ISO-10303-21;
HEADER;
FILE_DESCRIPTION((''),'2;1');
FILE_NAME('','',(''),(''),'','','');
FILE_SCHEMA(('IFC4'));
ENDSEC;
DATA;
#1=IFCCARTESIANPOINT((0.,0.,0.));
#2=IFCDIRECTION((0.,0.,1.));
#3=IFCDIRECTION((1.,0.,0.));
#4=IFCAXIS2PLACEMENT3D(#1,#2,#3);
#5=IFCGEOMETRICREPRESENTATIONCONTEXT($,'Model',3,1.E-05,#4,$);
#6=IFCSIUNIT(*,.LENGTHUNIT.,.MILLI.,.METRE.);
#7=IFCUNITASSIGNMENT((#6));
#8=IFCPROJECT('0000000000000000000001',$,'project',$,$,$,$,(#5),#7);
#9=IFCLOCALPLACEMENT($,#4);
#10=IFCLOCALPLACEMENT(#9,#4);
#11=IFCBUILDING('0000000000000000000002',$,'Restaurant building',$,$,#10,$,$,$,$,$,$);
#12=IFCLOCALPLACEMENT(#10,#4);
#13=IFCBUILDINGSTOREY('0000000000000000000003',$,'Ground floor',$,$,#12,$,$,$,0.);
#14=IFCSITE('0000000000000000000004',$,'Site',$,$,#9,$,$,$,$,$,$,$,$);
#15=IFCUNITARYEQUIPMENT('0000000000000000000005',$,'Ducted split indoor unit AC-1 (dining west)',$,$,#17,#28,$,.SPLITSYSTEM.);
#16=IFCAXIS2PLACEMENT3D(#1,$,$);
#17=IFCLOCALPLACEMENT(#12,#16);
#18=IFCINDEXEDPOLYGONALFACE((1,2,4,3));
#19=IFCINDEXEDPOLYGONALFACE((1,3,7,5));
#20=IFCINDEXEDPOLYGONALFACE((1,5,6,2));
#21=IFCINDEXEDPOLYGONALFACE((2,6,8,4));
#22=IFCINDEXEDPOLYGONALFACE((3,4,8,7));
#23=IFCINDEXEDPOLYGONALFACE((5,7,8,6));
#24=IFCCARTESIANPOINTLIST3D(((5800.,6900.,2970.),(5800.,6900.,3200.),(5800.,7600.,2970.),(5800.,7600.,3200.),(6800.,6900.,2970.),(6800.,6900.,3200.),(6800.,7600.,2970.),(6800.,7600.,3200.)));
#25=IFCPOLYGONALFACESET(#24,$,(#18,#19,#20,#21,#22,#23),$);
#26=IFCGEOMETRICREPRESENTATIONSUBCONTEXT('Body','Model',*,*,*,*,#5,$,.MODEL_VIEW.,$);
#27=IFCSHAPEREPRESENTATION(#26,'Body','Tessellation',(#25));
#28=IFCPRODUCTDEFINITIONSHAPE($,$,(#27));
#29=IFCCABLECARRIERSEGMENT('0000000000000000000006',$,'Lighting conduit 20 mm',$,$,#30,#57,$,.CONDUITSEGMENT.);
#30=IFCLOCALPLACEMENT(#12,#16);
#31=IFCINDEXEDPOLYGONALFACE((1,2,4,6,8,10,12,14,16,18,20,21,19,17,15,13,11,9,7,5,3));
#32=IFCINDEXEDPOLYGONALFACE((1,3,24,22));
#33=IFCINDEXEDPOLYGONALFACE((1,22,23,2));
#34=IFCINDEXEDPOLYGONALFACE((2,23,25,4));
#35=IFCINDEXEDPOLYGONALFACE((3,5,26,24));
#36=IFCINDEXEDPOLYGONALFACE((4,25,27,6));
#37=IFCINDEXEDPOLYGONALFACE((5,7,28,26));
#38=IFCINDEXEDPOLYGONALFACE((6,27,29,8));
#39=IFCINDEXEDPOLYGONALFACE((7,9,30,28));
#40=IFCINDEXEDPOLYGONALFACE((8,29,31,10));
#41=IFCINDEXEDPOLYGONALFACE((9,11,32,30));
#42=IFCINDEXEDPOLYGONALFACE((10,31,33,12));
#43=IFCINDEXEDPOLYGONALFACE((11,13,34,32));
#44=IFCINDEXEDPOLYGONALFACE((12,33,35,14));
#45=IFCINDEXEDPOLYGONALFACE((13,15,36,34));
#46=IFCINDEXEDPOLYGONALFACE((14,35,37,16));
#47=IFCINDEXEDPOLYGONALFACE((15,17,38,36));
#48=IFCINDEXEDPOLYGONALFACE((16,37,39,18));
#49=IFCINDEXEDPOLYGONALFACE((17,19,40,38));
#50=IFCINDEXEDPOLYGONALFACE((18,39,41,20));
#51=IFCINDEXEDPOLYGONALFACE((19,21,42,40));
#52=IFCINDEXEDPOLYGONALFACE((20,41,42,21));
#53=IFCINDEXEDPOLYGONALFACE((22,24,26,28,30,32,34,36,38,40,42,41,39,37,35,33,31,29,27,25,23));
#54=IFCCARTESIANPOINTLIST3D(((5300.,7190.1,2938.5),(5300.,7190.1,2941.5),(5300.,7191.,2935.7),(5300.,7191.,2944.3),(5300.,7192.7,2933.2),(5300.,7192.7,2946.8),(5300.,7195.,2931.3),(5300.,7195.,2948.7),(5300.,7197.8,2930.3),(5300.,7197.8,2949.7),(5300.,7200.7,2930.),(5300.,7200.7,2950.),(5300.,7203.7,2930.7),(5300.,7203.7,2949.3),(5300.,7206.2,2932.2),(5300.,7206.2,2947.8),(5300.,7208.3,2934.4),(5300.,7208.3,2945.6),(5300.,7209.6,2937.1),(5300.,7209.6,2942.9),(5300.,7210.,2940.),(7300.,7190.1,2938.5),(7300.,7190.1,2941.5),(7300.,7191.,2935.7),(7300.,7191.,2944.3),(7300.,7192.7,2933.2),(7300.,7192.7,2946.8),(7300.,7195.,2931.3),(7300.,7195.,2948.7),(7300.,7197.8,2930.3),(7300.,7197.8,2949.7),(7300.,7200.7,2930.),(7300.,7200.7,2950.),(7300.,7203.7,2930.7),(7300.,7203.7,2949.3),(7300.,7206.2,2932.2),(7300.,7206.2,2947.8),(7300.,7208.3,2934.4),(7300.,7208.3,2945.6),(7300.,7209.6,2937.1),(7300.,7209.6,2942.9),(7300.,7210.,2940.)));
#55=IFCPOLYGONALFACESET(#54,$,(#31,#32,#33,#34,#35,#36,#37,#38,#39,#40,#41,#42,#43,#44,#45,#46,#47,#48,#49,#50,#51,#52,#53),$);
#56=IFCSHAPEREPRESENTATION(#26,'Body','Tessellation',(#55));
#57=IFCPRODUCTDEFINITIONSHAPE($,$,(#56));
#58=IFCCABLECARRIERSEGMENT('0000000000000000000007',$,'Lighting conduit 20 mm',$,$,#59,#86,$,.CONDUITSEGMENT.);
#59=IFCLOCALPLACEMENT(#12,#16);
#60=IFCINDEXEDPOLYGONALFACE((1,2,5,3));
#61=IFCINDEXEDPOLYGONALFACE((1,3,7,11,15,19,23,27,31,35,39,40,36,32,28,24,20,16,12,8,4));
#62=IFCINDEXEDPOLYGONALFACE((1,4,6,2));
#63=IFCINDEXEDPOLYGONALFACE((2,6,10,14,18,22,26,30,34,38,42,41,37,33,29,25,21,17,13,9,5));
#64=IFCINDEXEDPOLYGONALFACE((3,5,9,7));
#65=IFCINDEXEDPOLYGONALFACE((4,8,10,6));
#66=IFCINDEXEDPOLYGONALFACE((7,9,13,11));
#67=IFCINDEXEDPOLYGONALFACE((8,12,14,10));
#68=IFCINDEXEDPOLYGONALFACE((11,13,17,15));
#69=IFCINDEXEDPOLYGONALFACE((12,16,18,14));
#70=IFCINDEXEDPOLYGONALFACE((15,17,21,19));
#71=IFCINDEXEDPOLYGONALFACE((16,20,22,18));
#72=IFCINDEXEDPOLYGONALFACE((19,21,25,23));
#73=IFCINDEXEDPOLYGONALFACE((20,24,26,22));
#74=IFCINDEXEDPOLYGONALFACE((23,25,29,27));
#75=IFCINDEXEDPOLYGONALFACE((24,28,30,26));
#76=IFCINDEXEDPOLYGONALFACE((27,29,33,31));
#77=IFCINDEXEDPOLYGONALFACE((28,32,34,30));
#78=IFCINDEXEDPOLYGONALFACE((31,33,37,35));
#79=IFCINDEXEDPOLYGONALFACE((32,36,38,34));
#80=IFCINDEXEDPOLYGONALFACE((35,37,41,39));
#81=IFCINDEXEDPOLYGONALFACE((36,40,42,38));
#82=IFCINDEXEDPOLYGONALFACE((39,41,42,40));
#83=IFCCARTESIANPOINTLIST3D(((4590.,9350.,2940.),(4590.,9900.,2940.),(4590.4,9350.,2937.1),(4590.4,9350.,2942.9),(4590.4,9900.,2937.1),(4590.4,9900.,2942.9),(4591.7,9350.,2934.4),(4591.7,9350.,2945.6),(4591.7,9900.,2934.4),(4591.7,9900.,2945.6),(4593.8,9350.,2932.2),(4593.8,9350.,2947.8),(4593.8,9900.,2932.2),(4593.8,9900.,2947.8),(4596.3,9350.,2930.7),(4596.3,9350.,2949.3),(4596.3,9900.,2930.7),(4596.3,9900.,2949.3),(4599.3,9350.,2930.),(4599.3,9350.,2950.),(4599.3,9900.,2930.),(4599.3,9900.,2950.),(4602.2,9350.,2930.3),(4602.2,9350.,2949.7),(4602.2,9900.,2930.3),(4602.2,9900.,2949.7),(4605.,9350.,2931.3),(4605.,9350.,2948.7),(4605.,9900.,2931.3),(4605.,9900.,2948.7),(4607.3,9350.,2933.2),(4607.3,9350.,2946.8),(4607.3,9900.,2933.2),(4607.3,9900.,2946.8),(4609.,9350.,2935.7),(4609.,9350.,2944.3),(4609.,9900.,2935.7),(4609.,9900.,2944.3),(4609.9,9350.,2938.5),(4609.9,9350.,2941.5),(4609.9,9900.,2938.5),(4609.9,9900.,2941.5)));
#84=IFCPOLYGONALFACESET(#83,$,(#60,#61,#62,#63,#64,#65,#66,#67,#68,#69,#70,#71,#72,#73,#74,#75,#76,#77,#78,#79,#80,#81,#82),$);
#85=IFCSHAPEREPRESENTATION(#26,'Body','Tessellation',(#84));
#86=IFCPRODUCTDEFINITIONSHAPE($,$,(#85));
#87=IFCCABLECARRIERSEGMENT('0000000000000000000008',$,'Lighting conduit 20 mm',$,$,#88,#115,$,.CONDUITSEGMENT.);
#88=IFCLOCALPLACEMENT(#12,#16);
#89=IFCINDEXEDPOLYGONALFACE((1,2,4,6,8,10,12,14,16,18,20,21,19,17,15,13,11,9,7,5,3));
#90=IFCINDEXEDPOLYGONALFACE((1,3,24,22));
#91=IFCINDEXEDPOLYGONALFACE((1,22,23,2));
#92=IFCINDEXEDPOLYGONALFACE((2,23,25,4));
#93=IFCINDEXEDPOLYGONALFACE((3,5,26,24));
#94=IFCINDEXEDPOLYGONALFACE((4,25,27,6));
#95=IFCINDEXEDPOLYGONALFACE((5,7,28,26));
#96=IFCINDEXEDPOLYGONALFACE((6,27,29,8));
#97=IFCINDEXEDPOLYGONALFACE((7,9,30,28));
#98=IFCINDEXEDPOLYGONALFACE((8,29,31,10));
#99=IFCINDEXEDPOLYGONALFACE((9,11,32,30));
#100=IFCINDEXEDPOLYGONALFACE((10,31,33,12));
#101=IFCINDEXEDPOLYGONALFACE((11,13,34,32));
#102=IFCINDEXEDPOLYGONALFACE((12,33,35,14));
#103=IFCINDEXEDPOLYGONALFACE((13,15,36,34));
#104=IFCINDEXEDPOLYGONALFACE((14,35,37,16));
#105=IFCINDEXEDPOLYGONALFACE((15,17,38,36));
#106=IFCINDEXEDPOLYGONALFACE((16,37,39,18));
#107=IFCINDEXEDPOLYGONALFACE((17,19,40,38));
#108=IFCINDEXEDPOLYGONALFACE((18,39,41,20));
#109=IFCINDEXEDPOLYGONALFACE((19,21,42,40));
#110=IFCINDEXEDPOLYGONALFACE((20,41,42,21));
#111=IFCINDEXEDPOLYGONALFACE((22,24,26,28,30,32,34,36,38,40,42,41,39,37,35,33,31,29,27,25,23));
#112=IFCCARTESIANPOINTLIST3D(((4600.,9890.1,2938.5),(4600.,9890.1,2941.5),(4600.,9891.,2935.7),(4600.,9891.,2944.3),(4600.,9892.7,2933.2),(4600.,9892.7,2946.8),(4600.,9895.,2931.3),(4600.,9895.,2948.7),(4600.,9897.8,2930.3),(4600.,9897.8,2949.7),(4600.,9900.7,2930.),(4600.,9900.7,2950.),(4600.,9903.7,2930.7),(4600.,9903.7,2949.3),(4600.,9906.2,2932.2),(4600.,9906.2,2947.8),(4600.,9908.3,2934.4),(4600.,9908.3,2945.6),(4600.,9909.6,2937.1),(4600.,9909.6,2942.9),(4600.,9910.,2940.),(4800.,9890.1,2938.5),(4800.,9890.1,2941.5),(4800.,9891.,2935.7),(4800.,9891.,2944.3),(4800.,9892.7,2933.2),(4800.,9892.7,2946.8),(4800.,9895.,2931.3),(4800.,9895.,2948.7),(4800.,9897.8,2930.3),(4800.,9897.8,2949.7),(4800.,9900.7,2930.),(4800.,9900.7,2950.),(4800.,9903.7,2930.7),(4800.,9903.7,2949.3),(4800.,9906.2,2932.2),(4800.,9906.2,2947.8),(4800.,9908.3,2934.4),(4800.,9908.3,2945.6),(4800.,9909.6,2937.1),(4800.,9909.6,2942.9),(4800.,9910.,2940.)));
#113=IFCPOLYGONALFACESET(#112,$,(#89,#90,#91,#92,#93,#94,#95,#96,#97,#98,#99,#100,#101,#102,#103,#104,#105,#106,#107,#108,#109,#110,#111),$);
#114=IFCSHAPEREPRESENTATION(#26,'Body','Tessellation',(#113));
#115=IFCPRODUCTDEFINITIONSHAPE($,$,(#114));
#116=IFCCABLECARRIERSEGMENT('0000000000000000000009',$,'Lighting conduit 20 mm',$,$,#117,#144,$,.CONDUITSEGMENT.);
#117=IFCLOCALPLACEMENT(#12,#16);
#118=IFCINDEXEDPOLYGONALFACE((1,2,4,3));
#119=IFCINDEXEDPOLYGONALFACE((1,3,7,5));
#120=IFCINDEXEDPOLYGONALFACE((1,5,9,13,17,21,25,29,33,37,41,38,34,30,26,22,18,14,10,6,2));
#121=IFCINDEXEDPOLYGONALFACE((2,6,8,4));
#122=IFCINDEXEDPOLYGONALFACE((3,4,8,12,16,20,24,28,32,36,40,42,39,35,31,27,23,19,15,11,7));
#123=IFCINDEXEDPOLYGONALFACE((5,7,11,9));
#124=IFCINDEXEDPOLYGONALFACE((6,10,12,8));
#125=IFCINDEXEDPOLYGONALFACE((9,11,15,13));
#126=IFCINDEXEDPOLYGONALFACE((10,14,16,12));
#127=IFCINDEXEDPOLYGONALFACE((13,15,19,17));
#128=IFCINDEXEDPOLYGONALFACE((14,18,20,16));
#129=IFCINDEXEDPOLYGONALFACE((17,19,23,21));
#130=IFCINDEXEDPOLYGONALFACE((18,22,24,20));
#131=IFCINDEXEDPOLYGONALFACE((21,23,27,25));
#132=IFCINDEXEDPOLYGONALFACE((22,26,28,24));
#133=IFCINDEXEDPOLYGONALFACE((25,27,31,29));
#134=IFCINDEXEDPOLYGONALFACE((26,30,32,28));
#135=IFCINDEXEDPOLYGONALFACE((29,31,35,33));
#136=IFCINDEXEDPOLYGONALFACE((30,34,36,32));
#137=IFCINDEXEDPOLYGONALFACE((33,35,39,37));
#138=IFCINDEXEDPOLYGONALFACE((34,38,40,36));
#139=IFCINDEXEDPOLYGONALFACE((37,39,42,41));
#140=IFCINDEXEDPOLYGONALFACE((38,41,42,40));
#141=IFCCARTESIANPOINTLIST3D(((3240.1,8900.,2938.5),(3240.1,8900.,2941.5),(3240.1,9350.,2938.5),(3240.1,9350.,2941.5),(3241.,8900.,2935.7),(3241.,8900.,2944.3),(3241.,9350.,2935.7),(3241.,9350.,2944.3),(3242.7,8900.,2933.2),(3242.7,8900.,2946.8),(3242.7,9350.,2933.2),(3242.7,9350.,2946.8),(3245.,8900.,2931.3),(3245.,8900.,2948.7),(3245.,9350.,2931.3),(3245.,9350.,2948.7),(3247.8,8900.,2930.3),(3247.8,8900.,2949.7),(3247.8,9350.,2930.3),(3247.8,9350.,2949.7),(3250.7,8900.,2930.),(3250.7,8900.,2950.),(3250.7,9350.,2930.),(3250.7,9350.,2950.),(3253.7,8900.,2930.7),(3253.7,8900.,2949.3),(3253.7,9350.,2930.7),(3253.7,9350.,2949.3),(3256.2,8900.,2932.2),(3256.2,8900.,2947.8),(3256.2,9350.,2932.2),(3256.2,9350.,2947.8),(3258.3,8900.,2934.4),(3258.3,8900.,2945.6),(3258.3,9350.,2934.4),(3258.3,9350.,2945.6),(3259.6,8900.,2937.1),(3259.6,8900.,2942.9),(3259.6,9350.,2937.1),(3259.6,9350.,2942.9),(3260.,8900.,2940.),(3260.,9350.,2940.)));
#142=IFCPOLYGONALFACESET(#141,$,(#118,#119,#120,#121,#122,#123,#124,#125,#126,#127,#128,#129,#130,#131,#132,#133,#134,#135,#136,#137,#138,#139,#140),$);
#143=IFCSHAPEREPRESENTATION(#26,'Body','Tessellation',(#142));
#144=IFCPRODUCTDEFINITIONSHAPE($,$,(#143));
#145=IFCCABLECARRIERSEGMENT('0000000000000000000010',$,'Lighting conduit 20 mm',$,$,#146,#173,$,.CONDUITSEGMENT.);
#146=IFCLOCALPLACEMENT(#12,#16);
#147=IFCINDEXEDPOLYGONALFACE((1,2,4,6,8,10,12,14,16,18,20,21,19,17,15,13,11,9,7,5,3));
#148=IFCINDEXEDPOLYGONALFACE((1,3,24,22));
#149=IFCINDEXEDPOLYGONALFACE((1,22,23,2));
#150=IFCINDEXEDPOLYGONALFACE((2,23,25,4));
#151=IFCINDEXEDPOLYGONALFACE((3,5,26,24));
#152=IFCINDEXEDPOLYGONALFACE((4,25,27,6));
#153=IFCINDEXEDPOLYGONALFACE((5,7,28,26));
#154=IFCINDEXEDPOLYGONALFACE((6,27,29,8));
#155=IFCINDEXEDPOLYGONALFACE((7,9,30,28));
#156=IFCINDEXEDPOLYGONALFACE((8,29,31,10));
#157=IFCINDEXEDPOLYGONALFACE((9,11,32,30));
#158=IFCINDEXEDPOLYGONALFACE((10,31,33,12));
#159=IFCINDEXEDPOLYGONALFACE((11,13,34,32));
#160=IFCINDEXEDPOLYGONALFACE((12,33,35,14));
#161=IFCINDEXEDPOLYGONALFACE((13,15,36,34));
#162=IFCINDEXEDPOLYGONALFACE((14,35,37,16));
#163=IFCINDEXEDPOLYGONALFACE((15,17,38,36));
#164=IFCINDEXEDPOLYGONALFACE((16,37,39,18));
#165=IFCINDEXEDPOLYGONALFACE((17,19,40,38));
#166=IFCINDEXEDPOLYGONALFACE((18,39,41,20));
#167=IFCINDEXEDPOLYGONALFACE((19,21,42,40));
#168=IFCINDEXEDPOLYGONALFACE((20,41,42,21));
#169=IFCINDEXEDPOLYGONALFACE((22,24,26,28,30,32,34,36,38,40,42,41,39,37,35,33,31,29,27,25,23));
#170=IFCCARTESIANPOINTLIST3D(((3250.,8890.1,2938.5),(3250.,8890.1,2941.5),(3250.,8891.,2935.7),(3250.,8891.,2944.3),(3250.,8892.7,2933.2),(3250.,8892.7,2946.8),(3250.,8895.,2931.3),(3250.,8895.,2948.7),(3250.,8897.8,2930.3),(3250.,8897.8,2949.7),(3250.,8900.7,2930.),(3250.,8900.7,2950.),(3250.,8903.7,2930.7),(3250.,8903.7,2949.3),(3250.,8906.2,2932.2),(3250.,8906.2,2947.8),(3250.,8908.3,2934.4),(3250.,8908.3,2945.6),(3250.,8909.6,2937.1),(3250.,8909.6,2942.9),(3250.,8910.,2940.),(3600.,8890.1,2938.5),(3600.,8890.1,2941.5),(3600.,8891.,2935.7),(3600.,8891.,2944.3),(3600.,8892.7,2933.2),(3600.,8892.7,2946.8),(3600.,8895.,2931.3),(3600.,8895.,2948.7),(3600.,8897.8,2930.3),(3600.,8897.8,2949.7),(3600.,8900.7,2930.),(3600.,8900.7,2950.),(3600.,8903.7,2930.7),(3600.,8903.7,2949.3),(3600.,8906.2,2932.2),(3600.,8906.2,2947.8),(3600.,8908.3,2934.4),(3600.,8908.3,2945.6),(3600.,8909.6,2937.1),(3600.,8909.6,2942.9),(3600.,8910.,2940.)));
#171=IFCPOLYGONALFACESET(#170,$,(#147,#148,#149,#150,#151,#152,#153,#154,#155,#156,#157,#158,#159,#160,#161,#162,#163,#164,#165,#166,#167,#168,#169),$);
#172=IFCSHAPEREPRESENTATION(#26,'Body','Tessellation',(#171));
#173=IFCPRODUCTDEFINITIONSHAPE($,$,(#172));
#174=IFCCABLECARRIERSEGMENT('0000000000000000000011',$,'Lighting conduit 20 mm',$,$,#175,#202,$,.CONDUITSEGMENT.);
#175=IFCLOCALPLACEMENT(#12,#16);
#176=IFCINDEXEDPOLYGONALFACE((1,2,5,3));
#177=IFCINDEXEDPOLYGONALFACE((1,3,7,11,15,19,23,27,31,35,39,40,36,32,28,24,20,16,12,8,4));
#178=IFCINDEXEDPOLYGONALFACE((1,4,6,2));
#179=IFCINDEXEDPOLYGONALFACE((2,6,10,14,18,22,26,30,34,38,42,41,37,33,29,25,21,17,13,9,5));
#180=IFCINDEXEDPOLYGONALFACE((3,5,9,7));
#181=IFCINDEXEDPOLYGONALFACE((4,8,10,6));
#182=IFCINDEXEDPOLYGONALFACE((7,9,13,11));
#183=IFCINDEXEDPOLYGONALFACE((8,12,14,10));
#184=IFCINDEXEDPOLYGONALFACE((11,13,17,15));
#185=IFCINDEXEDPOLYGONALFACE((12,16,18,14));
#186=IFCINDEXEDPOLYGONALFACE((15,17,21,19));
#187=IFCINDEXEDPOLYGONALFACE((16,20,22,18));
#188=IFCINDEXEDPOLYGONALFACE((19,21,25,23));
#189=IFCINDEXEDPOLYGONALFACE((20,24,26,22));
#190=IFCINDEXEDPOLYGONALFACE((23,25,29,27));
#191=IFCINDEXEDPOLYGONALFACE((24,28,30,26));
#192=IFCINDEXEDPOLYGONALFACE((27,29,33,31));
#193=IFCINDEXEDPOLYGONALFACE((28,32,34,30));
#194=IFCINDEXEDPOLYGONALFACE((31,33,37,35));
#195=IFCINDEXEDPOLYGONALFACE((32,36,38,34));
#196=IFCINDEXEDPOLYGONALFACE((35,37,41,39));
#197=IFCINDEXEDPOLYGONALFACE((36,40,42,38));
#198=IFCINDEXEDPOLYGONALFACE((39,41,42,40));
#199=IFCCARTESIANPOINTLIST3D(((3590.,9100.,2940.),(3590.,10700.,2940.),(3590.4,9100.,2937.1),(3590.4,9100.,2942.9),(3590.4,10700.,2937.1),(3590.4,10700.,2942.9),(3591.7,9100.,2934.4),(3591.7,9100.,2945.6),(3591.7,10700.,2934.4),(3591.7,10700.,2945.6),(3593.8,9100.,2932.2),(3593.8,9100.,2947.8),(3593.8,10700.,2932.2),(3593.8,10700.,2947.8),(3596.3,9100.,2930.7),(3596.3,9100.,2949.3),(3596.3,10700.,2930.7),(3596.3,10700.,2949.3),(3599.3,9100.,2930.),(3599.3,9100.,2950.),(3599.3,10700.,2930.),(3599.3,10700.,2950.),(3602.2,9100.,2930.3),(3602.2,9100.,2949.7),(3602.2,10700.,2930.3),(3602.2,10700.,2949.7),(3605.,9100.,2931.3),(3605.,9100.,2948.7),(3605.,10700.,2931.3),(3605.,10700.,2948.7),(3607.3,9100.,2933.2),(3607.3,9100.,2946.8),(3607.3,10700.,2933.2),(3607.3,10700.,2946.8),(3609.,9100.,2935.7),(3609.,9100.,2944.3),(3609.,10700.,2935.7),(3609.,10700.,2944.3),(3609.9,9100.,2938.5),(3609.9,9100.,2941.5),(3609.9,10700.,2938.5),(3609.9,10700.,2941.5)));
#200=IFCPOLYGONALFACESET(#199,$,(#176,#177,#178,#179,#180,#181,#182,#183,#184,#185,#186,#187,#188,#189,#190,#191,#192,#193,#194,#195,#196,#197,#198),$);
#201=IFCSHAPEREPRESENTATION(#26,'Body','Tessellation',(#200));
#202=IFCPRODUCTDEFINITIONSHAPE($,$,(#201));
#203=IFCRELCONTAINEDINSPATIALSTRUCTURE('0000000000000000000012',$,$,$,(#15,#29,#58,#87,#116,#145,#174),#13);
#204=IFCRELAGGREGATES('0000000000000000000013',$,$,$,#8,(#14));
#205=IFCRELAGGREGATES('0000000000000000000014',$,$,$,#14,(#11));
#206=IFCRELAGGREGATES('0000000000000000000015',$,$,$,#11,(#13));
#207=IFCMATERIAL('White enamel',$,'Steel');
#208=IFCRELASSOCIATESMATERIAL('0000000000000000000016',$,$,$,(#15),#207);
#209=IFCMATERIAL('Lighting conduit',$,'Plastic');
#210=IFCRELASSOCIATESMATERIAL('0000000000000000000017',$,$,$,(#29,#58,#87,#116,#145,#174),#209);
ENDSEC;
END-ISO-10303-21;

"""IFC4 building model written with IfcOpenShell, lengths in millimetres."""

from ifc_helpers import new_model, si_unit, frame, origin_with_axes, origin_2d, place, context, subcontext, project, spatial, rectangle, circle, extrude, material, element, save


model = new_model("IFC4")

# Units and contexts
model_context = context("Model", 3, precision=1e-05, world=origin_with_axes())
body_context = subcontext(model_context, "Body", "Model", "MODEL_VIEW")
ifc_project = project(units=[si_unit("LENGTHUNIT", "METRE", prefix="MILLI")], contexts=[model_context])

# Site, building, storey
site_placement = place(None, origin_with_axes())
site = spatial("IfcSite", under=ifc_project, at=site_placement, Name="Site")
building_placement = place(site_placement, origin_with_axes())
building = spatial("IfcBuilding", under=site, at=building_placement, Name="Restaurant building")
storey_placement = place(building_placement, origin_with_axes())
storey = spatial("IfcBuildingStorey", under=building, at=storey_placement, Name="Ground floor", Elevation=0.0)

# Shared definitions
ifc_material_1 = material(Name="White enamel", Category="Steel")

# Unitary equipment
unitary_equipment_placement = place(storey_placement, frame((6300.0, 7250.0, 0.0)))
element("IfcUnitaryEquipment", 1, at=unitary_equipment_placement, inside=storey, material=ifc_material_1, Name="Ducted split indoor unit AC-1 (dining west)", PredefinedType="SPLITSYSTEM", context=body_context, shape_type="SweptSolid", body=[
    extrude(rectangle(XDim=1000.0, YDim=700.0, at=origin_2d()), frame((0.0, 0.0, 2970.0)), (0.0, 0.0, 1.0), 230.0),
])

# Cable carrier segments
ifc_material_2 = material(Name="Lighting conduit", Category="Plastic")
cable_carrier_segment_1_placement = place(storey_placement, frame((5300.0, 7200.0, 2940.0)))
element("IfcCableCarrierSegment", 2, at=cable_carrier_segment_1_placement, inside=storey, material=ifc_material_2, Name="Lighting conduit 20 mm", PredefinedType="CONDUITSEGMENT", context=body_context, shape_type="SweptSolid", body=[
    extrude(circle(Radius=10.0, at=origin_2d()), frame((0.0, 0.0, 0.0), z_axis=(1.0, 0.0, 0.0), x_axis=(0.0, 1.0, 0.0)), (0.0, 0.0, 1.0), 2000.0),
])
cable_carrier_segment_2_placement = place(storey_placement, frame((4600.0, 9350.0, 2940.0)))
element("IfcCableCarrierSegment", 3, at=cable_carrier_segment_2_placement, inside=storey, material=ifc_material_2, Name="Lighting conduit 20 mm", PredefinedType="CONDUITSEGMENT", context=body_context, shape_type="SweptSolid", body=[
    extrude(circle(Radius=10.0, at=origin_2d()), frame((0.0, 0.0, 0.0), z_axis=(0.0, 1.0, 0.0), x_axis=(-1.0, 0.0, 0.0)), (0.0, 0.0, 1.0), 550.0),
])
cable_carrier_segment_3_placement = place(storey_placement, frame((4600.0, 9900.0, 2940.0)))
element("IfcCableCarrierSegment", 4, at=cable_carrier_segment_3_placement, inside=storey, material=ifc_material_2, Name="Lighting conduit 20 mm", PredefinedType="CONDUITSEGMENT", context=body_context, shape_type="SweptSolid", body=[
    extrude(circle(Radius=10.0, at=origin_2d()), frame((0.0, 0.0, 0.0), z_axis=(1.0, 0.0, 0.0), x_axis=(0.0, 1.0, 0.0)), (0.0, 0.0, 1.0), 200.0),
])
cable_carrier_segment_4_placement = place(storey_placement, frame((3250.0, 9350.0, 2940.0)))
element("IfcCableCarrierSegment", 5, at=cable_carrier_segment_4_placement, inside=storey, material=ifc_material_2, Name="Lighting conduit 20 mm", PredefinedType="CONDUITSEGMENT", context=body_context, shape_type="SweptSolid", body=[
    extrude(circle(Radius=10.0, at=origin_2d()), frame((0.0, 0.0, 0.0), z_axis=(0.0, -1.0, 0.0), x_axis=(1.0, 0.0, 0.0)), (0.0, 0.0, 1.0), 450.0),
])
cable_carrier_segment_5_placement = place(storey_placement, frame((3250.0, 8900.0, 2940.0)))
element("IfcCableCarrierSegment", 6, at=cable_carrier_segment_5_placement, inside=storey, material=ifc_material_2, Name="Lighting conduit 20 mm", PredefinedType="CONDUITSEGMENT", context=body_context, shape_type="SweptSolid", body=[
    extrude(circle(Radius=10.0, at=origin_2d()), frame((0.0, 0.0, 0.0), z_axis=(1.0, 0.0, 0.0), x_axis=(0.0, 1.0, 0.0)), (0.0, 0.0, 1.0), 350.0),
])
cable_carrier_segment_6_placement = place(storey_placement, frame((3600.0, 9100.0, 2940.0)))
element("IfcCableCarrierSegment", 7, at=cable_carrier_segment_6_placement, inside=storey, material=ifc_material_2, Name="Lighting conduit 20 mm", PredefinedType="CONDUITSEGMENT", context=body_context, shape_type="SweptSolid", body=[
    extrude(circle(Radius=10.0, at=origin_2d()), frame((0.0, 0.0, 0.0), z_axis=(0.0, 1.0, 0.0), x_axis=(-1.0, 0.0, 0.0)), (0.0, 0.0, 1.0), 1600.0),
])

save(model, "model.ifc")
